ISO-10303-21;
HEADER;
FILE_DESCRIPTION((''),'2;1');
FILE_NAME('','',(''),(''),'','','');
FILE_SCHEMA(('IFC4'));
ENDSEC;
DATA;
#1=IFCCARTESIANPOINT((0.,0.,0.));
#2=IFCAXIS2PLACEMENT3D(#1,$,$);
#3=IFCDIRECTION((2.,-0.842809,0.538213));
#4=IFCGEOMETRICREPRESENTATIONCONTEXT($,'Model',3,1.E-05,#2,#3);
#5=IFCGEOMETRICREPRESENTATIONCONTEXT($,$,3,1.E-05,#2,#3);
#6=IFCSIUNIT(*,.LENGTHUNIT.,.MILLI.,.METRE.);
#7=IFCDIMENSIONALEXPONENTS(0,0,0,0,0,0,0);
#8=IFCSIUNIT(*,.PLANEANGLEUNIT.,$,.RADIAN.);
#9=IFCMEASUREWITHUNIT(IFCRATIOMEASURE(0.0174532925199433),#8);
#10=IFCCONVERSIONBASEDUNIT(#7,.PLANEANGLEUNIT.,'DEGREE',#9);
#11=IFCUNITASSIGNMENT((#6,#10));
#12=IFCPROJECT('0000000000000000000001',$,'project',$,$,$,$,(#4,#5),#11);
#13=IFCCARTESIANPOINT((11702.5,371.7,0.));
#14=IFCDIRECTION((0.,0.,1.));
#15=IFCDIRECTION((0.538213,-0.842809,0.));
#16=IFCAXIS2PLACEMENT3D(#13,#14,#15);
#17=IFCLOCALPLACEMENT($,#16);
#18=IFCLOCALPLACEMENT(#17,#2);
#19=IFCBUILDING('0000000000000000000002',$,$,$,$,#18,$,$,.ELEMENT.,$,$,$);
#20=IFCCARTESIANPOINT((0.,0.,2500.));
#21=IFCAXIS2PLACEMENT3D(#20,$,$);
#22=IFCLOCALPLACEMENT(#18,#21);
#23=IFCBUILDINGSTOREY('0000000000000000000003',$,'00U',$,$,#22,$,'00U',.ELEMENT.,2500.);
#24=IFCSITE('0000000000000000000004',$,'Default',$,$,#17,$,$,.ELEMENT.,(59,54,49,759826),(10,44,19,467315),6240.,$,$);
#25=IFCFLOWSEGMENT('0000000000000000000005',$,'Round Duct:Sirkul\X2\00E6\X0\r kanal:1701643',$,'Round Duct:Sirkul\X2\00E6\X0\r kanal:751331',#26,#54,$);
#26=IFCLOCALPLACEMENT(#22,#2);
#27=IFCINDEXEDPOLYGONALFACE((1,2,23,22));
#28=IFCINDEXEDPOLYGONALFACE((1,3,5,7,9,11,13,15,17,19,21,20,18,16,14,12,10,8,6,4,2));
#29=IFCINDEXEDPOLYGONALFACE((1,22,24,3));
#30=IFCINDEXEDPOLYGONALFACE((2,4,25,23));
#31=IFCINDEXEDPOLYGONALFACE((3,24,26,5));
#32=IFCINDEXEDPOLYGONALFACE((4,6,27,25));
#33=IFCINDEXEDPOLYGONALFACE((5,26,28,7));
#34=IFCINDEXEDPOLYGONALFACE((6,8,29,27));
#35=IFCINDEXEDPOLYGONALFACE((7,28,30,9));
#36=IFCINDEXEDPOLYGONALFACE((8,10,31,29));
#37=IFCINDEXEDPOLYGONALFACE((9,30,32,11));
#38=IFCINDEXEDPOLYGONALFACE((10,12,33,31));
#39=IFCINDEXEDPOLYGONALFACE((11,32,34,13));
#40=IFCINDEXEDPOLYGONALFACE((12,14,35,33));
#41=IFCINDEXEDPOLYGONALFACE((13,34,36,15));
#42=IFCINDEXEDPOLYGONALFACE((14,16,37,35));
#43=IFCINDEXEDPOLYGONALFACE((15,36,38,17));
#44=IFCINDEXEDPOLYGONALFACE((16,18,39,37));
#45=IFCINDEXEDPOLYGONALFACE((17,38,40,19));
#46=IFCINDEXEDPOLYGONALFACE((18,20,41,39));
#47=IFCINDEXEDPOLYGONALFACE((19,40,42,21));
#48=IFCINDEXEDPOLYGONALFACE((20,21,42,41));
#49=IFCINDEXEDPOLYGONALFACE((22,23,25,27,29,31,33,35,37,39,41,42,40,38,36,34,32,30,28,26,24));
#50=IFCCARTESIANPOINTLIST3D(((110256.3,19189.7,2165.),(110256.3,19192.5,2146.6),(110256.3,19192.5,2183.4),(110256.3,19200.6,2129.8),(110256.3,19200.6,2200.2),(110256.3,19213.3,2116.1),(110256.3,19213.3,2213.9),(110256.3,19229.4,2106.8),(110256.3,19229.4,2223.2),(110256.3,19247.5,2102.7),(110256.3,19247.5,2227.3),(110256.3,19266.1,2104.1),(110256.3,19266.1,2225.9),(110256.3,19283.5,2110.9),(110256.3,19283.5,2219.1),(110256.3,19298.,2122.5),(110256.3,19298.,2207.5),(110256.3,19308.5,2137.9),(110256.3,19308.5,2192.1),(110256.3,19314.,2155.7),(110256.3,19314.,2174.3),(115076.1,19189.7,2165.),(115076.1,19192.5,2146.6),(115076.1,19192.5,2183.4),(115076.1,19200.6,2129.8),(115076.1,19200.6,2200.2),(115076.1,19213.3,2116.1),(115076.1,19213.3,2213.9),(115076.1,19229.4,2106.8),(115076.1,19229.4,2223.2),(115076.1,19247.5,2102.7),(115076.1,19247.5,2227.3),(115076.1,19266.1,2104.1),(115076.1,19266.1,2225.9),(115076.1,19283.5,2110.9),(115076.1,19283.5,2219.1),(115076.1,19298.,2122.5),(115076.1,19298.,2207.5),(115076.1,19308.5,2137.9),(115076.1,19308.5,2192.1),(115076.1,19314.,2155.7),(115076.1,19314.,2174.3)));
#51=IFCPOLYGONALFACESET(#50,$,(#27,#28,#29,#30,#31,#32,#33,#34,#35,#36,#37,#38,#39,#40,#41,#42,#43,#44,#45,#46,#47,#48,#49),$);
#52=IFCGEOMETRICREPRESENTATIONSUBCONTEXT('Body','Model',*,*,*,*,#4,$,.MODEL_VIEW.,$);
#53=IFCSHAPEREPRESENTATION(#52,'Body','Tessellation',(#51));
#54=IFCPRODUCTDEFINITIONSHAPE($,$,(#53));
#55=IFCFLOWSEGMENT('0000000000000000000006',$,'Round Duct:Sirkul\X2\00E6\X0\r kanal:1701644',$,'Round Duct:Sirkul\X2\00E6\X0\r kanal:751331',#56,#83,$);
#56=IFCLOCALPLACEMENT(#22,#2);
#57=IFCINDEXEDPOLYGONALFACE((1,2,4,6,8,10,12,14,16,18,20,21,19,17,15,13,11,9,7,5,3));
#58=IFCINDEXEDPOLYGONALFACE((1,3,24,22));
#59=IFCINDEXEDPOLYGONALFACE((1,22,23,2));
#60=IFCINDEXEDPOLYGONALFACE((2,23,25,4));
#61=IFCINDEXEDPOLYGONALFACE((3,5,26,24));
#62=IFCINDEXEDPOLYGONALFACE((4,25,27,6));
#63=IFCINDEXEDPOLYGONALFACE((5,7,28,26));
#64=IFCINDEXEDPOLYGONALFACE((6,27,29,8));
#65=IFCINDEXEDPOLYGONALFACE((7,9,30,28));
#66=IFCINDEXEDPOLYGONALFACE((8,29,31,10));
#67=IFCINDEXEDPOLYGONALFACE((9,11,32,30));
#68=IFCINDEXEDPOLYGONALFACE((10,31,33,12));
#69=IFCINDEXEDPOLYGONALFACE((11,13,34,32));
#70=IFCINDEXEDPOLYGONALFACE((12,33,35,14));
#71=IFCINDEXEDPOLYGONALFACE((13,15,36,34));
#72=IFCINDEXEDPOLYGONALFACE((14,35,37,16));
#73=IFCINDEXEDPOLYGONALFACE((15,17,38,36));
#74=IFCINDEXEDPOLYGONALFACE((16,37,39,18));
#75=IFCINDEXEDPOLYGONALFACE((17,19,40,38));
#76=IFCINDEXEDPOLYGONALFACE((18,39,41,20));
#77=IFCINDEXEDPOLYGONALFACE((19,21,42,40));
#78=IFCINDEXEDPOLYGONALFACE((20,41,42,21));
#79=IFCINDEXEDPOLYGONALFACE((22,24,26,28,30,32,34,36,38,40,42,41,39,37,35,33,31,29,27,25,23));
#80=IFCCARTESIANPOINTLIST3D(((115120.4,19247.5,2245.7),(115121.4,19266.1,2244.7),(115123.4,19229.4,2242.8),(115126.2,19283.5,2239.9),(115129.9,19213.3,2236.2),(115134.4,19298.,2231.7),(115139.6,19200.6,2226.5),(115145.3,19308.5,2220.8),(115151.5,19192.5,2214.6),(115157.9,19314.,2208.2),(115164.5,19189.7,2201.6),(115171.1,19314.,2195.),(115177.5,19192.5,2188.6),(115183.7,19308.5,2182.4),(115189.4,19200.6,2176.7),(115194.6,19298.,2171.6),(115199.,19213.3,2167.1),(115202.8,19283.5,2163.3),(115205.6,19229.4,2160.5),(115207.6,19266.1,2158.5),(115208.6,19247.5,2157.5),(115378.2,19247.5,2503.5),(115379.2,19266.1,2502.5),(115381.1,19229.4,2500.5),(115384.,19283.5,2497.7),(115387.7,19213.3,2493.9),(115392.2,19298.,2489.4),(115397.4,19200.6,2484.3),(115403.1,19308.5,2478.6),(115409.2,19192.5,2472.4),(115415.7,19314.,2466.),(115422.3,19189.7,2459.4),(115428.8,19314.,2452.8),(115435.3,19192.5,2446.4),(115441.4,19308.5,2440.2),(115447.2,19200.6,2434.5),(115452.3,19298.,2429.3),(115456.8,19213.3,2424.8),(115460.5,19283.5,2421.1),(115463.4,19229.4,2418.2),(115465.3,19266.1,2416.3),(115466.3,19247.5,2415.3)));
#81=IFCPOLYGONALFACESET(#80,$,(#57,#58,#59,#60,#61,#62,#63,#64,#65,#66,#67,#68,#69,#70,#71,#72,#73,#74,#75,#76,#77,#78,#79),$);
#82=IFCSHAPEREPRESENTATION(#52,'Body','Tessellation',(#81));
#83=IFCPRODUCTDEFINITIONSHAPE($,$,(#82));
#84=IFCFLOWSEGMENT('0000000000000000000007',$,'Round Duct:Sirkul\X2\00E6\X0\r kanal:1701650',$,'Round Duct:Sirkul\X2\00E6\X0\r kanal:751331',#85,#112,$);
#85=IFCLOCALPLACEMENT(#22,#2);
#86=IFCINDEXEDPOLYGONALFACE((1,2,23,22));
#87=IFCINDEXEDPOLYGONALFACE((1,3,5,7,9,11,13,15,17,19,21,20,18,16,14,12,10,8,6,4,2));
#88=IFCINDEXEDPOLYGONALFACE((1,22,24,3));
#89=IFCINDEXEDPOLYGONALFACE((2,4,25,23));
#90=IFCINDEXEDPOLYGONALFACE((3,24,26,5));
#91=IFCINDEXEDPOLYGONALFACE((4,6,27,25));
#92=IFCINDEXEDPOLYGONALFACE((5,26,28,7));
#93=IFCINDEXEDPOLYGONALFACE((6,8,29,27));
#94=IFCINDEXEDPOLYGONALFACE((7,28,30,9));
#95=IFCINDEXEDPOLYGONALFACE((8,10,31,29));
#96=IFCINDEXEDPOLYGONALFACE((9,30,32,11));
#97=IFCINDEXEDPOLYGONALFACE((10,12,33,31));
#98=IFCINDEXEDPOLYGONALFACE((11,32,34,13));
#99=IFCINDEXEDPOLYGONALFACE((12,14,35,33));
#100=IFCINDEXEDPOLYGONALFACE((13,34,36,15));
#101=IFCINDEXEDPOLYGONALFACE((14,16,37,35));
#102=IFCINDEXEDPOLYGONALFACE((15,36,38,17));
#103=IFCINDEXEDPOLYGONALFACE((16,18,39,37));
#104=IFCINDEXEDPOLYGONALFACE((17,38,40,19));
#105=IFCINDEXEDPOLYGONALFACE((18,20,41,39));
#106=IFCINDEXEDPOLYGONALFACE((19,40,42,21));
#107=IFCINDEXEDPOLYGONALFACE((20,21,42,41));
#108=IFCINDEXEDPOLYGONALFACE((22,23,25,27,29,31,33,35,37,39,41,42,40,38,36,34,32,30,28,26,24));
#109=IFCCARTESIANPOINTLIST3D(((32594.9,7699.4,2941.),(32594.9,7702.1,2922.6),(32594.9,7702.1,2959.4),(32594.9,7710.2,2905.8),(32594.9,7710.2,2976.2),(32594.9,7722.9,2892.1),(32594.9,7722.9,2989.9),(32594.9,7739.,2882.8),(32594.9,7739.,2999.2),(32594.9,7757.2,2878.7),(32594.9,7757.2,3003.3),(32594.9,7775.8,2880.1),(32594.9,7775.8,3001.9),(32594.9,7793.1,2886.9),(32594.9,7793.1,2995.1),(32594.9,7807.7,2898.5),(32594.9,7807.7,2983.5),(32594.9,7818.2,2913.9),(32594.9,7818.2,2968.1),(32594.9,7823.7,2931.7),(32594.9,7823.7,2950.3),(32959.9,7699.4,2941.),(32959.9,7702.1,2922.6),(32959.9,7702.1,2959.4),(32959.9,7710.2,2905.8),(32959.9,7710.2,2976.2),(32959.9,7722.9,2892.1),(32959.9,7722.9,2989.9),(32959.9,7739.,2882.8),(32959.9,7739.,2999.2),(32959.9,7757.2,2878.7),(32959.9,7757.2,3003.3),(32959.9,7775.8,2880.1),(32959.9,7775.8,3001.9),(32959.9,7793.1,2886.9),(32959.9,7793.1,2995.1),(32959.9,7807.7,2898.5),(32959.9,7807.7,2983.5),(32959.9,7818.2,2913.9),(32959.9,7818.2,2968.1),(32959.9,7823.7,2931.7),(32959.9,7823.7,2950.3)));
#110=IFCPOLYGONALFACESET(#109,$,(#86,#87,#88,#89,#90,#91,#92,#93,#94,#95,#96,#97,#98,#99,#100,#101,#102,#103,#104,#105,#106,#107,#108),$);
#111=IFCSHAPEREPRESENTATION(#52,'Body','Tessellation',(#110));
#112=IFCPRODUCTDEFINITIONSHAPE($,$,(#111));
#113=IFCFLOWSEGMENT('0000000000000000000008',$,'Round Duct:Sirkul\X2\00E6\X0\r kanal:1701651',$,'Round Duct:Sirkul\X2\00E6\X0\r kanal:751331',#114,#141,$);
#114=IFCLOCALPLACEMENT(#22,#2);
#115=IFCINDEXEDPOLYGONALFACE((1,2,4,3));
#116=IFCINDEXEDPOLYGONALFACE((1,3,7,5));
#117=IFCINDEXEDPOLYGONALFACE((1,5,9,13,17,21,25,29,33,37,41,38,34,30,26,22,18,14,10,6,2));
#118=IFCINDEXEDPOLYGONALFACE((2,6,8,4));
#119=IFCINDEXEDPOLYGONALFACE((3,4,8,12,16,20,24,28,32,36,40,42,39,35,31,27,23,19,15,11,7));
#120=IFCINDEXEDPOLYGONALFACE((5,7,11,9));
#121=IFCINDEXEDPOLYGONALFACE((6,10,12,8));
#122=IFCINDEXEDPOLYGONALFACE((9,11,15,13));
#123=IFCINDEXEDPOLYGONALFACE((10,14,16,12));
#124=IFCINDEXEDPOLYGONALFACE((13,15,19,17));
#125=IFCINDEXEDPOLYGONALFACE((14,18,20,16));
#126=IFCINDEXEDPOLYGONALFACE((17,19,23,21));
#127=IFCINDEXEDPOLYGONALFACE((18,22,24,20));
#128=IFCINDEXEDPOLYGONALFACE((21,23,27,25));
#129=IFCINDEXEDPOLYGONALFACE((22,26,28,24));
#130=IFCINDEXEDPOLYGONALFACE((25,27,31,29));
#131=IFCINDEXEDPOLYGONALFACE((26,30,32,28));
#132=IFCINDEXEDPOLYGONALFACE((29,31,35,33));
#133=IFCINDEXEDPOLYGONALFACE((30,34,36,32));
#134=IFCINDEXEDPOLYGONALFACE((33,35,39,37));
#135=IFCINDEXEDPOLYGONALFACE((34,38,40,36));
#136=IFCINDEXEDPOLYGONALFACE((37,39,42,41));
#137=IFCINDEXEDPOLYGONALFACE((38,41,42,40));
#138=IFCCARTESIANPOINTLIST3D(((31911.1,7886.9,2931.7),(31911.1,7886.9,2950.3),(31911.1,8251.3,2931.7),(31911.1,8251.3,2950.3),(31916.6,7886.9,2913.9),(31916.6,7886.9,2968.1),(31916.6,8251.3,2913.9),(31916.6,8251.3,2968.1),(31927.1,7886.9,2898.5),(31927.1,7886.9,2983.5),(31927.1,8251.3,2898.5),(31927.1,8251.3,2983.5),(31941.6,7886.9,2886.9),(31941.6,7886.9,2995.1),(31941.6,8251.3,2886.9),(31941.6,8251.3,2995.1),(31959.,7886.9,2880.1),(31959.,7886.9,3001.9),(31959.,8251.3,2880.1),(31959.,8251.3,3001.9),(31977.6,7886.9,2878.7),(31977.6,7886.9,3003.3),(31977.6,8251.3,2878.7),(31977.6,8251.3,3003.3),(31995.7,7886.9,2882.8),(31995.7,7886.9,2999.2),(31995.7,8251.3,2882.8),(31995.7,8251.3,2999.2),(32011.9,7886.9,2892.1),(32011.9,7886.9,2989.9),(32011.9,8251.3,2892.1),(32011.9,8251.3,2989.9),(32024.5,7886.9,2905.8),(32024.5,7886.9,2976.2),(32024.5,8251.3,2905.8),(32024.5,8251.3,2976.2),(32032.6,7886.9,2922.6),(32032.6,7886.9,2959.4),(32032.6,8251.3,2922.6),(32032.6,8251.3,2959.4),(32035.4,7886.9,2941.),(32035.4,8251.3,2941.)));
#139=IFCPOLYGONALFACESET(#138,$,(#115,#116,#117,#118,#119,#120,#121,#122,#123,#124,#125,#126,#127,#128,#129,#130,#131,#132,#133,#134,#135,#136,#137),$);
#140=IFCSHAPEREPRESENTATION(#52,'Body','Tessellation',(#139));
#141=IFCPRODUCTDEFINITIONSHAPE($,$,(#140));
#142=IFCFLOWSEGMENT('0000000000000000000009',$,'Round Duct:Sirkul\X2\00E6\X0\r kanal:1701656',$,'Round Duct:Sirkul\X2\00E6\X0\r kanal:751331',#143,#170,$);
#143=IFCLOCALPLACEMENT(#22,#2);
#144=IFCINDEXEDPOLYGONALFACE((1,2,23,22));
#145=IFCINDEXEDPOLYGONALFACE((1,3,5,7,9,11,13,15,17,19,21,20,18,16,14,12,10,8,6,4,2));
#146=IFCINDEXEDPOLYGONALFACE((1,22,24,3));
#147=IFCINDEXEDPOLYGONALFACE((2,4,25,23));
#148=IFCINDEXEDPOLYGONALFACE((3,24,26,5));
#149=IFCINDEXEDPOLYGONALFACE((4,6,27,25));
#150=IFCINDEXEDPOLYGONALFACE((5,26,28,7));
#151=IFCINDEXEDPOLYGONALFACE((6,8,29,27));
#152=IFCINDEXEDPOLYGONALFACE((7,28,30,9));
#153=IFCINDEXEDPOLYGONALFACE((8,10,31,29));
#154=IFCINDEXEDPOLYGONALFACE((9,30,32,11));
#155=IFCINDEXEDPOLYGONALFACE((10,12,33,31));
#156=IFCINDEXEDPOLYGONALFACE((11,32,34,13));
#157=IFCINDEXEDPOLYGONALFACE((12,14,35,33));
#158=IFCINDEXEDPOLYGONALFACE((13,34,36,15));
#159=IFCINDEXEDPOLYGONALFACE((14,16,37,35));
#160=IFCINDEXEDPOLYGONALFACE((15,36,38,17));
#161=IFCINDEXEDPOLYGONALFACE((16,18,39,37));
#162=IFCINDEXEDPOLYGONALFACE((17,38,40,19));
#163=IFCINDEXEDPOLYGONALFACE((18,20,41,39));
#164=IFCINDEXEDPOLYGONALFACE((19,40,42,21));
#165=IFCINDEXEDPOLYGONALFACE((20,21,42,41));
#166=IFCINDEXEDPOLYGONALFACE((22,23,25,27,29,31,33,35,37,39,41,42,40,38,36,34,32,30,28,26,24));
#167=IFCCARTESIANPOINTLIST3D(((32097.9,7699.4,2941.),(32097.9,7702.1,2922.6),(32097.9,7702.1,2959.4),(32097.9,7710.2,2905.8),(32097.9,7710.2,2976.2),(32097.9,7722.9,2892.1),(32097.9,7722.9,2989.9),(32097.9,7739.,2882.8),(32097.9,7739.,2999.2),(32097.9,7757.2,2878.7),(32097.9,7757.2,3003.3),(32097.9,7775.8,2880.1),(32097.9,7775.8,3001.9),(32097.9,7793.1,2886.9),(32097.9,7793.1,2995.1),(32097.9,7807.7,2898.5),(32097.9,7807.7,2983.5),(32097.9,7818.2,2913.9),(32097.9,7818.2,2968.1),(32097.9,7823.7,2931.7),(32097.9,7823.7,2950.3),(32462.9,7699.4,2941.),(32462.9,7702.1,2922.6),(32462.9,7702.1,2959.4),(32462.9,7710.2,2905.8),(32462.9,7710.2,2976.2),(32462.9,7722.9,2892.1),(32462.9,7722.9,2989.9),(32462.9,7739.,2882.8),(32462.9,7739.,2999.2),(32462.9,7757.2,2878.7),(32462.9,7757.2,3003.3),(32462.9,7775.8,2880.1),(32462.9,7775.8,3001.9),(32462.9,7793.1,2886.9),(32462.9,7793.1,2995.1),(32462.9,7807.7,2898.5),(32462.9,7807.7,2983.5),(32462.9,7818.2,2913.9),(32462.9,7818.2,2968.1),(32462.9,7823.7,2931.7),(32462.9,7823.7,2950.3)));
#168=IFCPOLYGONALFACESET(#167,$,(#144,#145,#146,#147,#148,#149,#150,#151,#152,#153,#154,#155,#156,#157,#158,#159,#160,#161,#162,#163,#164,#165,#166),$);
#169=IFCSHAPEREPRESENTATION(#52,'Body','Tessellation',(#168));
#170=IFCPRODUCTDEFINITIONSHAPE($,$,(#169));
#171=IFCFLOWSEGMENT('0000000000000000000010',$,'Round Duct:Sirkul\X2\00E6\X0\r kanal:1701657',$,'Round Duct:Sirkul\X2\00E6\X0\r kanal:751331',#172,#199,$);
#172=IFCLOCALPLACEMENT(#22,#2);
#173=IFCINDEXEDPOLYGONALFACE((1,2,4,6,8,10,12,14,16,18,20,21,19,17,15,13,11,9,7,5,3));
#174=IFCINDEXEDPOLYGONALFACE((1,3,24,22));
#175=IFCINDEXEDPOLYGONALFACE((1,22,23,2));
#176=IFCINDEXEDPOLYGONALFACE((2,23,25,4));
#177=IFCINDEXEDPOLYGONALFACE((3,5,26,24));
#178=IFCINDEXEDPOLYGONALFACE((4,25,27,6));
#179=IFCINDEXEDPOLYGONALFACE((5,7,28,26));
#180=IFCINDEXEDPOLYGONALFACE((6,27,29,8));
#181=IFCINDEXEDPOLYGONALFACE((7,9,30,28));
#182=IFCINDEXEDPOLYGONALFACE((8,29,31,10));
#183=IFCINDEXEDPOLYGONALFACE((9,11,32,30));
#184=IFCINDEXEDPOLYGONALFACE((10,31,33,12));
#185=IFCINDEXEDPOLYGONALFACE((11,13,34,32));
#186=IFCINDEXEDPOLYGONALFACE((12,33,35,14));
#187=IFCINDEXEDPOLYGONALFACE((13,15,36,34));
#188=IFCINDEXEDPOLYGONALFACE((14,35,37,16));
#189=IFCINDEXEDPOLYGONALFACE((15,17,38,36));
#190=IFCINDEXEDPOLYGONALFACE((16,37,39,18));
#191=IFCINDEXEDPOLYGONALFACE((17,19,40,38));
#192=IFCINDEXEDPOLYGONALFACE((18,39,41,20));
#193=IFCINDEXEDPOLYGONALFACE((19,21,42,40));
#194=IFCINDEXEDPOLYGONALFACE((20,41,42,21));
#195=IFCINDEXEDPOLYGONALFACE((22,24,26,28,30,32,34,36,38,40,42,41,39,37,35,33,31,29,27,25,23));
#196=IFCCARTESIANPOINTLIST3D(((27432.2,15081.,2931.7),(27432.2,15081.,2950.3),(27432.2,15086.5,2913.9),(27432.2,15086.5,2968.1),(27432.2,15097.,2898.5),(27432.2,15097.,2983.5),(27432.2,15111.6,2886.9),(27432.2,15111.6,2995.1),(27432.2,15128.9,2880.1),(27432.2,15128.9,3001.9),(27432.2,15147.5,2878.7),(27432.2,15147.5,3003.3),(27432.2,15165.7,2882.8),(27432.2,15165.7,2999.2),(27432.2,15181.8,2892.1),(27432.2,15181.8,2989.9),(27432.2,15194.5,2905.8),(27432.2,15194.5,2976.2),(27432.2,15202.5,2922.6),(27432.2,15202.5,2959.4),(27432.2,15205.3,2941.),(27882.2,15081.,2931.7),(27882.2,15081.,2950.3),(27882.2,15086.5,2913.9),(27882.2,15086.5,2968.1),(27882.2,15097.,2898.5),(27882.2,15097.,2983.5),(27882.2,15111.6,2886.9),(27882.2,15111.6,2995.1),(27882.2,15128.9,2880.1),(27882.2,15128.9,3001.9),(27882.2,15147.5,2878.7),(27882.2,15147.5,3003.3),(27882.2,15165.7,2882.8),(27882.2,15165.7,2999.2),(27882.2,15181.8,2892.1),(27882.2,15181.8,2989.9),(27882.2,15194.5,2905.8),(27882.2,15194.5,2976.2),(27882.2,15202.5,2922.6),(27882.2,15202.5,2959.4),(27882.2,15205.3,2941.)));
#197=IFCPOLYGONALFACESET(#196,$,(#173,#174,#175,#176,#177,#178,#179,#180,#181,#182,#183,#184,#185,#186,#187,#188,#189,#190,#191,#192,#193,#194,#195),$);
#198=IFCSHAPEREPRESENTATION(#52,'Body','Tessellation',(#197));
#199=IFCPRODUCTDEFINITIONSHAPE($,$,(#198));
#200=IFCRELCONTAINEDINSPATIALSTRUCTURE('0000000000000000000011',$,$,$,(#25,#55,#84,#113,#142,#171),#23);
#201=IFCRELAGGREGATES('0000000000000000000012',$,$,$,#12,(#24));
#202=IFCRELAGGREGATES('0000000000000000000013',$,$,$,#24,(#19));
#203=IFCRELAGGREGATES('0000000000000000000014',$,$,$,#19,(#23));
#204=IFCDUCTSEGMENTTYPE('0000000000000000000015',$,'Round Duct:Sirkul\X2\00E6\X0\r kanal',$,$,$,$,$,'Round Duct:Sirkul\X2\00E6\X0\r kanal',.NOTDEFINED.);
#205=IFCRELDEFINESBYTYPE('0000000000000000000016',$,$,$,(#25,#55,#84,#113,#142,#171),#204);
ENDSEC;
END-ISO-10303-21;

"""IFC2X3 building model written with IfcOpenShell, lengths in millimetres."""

from ifc_helpers import new_model, entity, si_unit, converted_unit, direction, frame, frame_2d, origin, origin_2d_with_axis, place, context, subcontext, project, spatial, circle, extrude, type_object, element, save


model = new_model("IFC2X3")

# Units and contexts
model_context = context("Model", 3, precision=1e-05, world=origin(), true_north=direction((2.0, -0.842809, 0.538213)))
context_of_model = context(None, 3, precision=1e-05, world=origin(), true_north=direction((2.0, -0.842809, 0.538213)))
body_context = subcontext(model_context, "Body", "Model", "MODEL_VIEW")
ifc_project = project(units=[si_unit("LENGTHUNIT", "METRE", prefix="MILLI"), converted_unit("PLANEANGLEUNIT", "DEGREE", entity("IfcRatioMeasure", 0.0174532925199433), si_unit("PLANEANGLEUNIT", "RADIAN"), dimensions=[0, 0, 0, 0, 0, 0, 0])], contexts=[model_context, context_of_model])

# Site, building, storey
site_placement = place(None, frame((11702.5, 371.7, 0.0), z_axis=(0.0, 0.0, 1.0), x_axis=(0.538213, -0.842809, 0.0)))
site = spatial("IfcSite", under=ifc_project, at=site_placement, Name="Default", CompositionType="ELEMENT", RefLatitude=(59, 54, 49, 759826), RefLongitude=(10, 44, 19, 467315), RefElevation=6240.0)
building_placement = place(site_placement, origin())
building = spatial("IfcBuilding", under=site, at=building_placement, CompositionType="ELEMENT")
storey_placement = place(building_placement, frame((0.0, 0.0, 2500.0)))
storey = spatial("IfcBuildingStorey", under=building, at=storey_placement, Name="00U", LongName="00U", CompositionType="ELEMENT", Elevation=2500.0)

# Flow segments
duct_segment_type = type_object("IfcDuctSegmentType", Name="Round Duct:Sirkulær kanal", ElementType="Round Duct:Sirkulær kanal", PredefinedType="NOTDEFINED")
flow_segment_1_placement = place(storey_placement, origin())
element("IfcFlowSegment", 1, at=flow_segment_1_placement, inside=storey, type_object=duct_segment_type, Name="Round Duct:Sirkulær kanal:1701643", ObjectType="Round Duct:Sirkulær kanal:751331", context=body_context, shape_type="SweptSolid", body=[
    extrude(circle(Radius=62.5, at=origin_2d_with_axis()), frame((110256.3, 19252.2, 2165.0), z_axis=(1.0, 0.0, 0.0), x_axis=(0.0, -1.0, 0.0)), (0.0, 0.0, 1.0), 4819.8),
])
flow_segment_2_placement = place(storey_placement, origin())
element("IfcFlowSegment", 2, at=flow_segment_2_placement, inside=storey, type_object=duct_segment_type, Name="Round Duct:Sirkulær kanal:1701644", ObjectType="Round Duct:Sirkulær kanal:751331", context=body_context, shape_type="SweptSolid", body=[
    extrude(circle(Radius=62.5, at=frame_2d((0.0, 0.0), x_axis=(1.0, 0.0))), frame((115164.5, 19252.2, 2201.6), z_axis=(0.707107, 0.0, 0.707107), x_axis=(0.0, -1.0, 0.0)), (0.0, 0.0, 1.0), 364.5),
])
flow_segment_3_placement = place(storey_placement, origin())
element("IfcFlowSegment", 3, at=flow_segment_3_placement, inside=storey, type_object=duct_segment_type, Name="Round Duct:Sirkulær kanal:1701650", ObjectType="Round Duct:Sirkulær kanal:751331", context=body_context, shape_type="SweptSolid", body=[
    extrude(circle(Radius=62.5, at=origin_2d_with_axis()), frame((32594.9, 7761.9, 2941.0), z_axis=(1.0, 0.0, 0.0), x_axis=(0.0, -1.0, 0.0)), (0.0, 0.0, 1.0), 365.0),
])
flow_segment_4_placement = place(storey_placement, origin())
element("IfcFlowSegment", 4, at=flow_segment_4_placement, inside=storey, type_object=duct_segment_type, Name="Round Duct:Sirkulær kanal:1701651", ObjectType="Round Duct:Sirkulær kanal:751331", context=body_context, shape_type="SweptSolid", body=[
    extrude(circle(Radius=62.5, at=frame_2d((0.0, 0.0), x_axis=(1.0, 0.0))), frame((31972.9, 7886.9, 2941.0), z_axis=(0.0, 1.0, 0.0), x_axis=(1.0, 0.0, 0.0)), (0.0, 0.0, 1.0), 364.4),
])
flow_segment_5_placement = place(storey_placement, origin())
element("IfcFlowSegment", 5, at=flow_segment_5_placement, inside=storey, type_object=duct_segment_type, Name="Round Duct:Sirkulær kanal:1701656", ObjectType="Round Duct:Sirkulær kanal:751331", context=body_context, shape_type="SweptSolid", body=[
    extrude(circle(Radius=62.5, at=origin_2d_with_axis()), frame((32097.9, 7761.9, 2941.0), z_axis=(1.0, 0.0, 0.0), x_axis=(0.0, -1.0, 0.0)), (0.0, 0.0, 1.0), 365.0),
])
flow_segment_6_placement = place(storey_placement, origin())
element("IfcFlowSegment", 6, at=flow_segment_6_placement, inside=storey, type_object=duct_segment_type, Name="Round Duct:Sirkulær kanal:1701657", ObjectType="Round Duct:Sirkulær kanal:751331", context=body_context, shape_type="SweptSolid", body=[
    extrude(circle(Radius=62.5, at=frame_2d((0.0, 0.0), x_axis=(1.0, 0.0))), frame((27432.2, 15142.8, 2941.0), z_axis=(1.0, 0.0, 0.0), x_axis=(0.0, 1.0, 0.0)), (0.0, 0.0, 1.0), 449.9),
])

save(model, "model.ifc")
